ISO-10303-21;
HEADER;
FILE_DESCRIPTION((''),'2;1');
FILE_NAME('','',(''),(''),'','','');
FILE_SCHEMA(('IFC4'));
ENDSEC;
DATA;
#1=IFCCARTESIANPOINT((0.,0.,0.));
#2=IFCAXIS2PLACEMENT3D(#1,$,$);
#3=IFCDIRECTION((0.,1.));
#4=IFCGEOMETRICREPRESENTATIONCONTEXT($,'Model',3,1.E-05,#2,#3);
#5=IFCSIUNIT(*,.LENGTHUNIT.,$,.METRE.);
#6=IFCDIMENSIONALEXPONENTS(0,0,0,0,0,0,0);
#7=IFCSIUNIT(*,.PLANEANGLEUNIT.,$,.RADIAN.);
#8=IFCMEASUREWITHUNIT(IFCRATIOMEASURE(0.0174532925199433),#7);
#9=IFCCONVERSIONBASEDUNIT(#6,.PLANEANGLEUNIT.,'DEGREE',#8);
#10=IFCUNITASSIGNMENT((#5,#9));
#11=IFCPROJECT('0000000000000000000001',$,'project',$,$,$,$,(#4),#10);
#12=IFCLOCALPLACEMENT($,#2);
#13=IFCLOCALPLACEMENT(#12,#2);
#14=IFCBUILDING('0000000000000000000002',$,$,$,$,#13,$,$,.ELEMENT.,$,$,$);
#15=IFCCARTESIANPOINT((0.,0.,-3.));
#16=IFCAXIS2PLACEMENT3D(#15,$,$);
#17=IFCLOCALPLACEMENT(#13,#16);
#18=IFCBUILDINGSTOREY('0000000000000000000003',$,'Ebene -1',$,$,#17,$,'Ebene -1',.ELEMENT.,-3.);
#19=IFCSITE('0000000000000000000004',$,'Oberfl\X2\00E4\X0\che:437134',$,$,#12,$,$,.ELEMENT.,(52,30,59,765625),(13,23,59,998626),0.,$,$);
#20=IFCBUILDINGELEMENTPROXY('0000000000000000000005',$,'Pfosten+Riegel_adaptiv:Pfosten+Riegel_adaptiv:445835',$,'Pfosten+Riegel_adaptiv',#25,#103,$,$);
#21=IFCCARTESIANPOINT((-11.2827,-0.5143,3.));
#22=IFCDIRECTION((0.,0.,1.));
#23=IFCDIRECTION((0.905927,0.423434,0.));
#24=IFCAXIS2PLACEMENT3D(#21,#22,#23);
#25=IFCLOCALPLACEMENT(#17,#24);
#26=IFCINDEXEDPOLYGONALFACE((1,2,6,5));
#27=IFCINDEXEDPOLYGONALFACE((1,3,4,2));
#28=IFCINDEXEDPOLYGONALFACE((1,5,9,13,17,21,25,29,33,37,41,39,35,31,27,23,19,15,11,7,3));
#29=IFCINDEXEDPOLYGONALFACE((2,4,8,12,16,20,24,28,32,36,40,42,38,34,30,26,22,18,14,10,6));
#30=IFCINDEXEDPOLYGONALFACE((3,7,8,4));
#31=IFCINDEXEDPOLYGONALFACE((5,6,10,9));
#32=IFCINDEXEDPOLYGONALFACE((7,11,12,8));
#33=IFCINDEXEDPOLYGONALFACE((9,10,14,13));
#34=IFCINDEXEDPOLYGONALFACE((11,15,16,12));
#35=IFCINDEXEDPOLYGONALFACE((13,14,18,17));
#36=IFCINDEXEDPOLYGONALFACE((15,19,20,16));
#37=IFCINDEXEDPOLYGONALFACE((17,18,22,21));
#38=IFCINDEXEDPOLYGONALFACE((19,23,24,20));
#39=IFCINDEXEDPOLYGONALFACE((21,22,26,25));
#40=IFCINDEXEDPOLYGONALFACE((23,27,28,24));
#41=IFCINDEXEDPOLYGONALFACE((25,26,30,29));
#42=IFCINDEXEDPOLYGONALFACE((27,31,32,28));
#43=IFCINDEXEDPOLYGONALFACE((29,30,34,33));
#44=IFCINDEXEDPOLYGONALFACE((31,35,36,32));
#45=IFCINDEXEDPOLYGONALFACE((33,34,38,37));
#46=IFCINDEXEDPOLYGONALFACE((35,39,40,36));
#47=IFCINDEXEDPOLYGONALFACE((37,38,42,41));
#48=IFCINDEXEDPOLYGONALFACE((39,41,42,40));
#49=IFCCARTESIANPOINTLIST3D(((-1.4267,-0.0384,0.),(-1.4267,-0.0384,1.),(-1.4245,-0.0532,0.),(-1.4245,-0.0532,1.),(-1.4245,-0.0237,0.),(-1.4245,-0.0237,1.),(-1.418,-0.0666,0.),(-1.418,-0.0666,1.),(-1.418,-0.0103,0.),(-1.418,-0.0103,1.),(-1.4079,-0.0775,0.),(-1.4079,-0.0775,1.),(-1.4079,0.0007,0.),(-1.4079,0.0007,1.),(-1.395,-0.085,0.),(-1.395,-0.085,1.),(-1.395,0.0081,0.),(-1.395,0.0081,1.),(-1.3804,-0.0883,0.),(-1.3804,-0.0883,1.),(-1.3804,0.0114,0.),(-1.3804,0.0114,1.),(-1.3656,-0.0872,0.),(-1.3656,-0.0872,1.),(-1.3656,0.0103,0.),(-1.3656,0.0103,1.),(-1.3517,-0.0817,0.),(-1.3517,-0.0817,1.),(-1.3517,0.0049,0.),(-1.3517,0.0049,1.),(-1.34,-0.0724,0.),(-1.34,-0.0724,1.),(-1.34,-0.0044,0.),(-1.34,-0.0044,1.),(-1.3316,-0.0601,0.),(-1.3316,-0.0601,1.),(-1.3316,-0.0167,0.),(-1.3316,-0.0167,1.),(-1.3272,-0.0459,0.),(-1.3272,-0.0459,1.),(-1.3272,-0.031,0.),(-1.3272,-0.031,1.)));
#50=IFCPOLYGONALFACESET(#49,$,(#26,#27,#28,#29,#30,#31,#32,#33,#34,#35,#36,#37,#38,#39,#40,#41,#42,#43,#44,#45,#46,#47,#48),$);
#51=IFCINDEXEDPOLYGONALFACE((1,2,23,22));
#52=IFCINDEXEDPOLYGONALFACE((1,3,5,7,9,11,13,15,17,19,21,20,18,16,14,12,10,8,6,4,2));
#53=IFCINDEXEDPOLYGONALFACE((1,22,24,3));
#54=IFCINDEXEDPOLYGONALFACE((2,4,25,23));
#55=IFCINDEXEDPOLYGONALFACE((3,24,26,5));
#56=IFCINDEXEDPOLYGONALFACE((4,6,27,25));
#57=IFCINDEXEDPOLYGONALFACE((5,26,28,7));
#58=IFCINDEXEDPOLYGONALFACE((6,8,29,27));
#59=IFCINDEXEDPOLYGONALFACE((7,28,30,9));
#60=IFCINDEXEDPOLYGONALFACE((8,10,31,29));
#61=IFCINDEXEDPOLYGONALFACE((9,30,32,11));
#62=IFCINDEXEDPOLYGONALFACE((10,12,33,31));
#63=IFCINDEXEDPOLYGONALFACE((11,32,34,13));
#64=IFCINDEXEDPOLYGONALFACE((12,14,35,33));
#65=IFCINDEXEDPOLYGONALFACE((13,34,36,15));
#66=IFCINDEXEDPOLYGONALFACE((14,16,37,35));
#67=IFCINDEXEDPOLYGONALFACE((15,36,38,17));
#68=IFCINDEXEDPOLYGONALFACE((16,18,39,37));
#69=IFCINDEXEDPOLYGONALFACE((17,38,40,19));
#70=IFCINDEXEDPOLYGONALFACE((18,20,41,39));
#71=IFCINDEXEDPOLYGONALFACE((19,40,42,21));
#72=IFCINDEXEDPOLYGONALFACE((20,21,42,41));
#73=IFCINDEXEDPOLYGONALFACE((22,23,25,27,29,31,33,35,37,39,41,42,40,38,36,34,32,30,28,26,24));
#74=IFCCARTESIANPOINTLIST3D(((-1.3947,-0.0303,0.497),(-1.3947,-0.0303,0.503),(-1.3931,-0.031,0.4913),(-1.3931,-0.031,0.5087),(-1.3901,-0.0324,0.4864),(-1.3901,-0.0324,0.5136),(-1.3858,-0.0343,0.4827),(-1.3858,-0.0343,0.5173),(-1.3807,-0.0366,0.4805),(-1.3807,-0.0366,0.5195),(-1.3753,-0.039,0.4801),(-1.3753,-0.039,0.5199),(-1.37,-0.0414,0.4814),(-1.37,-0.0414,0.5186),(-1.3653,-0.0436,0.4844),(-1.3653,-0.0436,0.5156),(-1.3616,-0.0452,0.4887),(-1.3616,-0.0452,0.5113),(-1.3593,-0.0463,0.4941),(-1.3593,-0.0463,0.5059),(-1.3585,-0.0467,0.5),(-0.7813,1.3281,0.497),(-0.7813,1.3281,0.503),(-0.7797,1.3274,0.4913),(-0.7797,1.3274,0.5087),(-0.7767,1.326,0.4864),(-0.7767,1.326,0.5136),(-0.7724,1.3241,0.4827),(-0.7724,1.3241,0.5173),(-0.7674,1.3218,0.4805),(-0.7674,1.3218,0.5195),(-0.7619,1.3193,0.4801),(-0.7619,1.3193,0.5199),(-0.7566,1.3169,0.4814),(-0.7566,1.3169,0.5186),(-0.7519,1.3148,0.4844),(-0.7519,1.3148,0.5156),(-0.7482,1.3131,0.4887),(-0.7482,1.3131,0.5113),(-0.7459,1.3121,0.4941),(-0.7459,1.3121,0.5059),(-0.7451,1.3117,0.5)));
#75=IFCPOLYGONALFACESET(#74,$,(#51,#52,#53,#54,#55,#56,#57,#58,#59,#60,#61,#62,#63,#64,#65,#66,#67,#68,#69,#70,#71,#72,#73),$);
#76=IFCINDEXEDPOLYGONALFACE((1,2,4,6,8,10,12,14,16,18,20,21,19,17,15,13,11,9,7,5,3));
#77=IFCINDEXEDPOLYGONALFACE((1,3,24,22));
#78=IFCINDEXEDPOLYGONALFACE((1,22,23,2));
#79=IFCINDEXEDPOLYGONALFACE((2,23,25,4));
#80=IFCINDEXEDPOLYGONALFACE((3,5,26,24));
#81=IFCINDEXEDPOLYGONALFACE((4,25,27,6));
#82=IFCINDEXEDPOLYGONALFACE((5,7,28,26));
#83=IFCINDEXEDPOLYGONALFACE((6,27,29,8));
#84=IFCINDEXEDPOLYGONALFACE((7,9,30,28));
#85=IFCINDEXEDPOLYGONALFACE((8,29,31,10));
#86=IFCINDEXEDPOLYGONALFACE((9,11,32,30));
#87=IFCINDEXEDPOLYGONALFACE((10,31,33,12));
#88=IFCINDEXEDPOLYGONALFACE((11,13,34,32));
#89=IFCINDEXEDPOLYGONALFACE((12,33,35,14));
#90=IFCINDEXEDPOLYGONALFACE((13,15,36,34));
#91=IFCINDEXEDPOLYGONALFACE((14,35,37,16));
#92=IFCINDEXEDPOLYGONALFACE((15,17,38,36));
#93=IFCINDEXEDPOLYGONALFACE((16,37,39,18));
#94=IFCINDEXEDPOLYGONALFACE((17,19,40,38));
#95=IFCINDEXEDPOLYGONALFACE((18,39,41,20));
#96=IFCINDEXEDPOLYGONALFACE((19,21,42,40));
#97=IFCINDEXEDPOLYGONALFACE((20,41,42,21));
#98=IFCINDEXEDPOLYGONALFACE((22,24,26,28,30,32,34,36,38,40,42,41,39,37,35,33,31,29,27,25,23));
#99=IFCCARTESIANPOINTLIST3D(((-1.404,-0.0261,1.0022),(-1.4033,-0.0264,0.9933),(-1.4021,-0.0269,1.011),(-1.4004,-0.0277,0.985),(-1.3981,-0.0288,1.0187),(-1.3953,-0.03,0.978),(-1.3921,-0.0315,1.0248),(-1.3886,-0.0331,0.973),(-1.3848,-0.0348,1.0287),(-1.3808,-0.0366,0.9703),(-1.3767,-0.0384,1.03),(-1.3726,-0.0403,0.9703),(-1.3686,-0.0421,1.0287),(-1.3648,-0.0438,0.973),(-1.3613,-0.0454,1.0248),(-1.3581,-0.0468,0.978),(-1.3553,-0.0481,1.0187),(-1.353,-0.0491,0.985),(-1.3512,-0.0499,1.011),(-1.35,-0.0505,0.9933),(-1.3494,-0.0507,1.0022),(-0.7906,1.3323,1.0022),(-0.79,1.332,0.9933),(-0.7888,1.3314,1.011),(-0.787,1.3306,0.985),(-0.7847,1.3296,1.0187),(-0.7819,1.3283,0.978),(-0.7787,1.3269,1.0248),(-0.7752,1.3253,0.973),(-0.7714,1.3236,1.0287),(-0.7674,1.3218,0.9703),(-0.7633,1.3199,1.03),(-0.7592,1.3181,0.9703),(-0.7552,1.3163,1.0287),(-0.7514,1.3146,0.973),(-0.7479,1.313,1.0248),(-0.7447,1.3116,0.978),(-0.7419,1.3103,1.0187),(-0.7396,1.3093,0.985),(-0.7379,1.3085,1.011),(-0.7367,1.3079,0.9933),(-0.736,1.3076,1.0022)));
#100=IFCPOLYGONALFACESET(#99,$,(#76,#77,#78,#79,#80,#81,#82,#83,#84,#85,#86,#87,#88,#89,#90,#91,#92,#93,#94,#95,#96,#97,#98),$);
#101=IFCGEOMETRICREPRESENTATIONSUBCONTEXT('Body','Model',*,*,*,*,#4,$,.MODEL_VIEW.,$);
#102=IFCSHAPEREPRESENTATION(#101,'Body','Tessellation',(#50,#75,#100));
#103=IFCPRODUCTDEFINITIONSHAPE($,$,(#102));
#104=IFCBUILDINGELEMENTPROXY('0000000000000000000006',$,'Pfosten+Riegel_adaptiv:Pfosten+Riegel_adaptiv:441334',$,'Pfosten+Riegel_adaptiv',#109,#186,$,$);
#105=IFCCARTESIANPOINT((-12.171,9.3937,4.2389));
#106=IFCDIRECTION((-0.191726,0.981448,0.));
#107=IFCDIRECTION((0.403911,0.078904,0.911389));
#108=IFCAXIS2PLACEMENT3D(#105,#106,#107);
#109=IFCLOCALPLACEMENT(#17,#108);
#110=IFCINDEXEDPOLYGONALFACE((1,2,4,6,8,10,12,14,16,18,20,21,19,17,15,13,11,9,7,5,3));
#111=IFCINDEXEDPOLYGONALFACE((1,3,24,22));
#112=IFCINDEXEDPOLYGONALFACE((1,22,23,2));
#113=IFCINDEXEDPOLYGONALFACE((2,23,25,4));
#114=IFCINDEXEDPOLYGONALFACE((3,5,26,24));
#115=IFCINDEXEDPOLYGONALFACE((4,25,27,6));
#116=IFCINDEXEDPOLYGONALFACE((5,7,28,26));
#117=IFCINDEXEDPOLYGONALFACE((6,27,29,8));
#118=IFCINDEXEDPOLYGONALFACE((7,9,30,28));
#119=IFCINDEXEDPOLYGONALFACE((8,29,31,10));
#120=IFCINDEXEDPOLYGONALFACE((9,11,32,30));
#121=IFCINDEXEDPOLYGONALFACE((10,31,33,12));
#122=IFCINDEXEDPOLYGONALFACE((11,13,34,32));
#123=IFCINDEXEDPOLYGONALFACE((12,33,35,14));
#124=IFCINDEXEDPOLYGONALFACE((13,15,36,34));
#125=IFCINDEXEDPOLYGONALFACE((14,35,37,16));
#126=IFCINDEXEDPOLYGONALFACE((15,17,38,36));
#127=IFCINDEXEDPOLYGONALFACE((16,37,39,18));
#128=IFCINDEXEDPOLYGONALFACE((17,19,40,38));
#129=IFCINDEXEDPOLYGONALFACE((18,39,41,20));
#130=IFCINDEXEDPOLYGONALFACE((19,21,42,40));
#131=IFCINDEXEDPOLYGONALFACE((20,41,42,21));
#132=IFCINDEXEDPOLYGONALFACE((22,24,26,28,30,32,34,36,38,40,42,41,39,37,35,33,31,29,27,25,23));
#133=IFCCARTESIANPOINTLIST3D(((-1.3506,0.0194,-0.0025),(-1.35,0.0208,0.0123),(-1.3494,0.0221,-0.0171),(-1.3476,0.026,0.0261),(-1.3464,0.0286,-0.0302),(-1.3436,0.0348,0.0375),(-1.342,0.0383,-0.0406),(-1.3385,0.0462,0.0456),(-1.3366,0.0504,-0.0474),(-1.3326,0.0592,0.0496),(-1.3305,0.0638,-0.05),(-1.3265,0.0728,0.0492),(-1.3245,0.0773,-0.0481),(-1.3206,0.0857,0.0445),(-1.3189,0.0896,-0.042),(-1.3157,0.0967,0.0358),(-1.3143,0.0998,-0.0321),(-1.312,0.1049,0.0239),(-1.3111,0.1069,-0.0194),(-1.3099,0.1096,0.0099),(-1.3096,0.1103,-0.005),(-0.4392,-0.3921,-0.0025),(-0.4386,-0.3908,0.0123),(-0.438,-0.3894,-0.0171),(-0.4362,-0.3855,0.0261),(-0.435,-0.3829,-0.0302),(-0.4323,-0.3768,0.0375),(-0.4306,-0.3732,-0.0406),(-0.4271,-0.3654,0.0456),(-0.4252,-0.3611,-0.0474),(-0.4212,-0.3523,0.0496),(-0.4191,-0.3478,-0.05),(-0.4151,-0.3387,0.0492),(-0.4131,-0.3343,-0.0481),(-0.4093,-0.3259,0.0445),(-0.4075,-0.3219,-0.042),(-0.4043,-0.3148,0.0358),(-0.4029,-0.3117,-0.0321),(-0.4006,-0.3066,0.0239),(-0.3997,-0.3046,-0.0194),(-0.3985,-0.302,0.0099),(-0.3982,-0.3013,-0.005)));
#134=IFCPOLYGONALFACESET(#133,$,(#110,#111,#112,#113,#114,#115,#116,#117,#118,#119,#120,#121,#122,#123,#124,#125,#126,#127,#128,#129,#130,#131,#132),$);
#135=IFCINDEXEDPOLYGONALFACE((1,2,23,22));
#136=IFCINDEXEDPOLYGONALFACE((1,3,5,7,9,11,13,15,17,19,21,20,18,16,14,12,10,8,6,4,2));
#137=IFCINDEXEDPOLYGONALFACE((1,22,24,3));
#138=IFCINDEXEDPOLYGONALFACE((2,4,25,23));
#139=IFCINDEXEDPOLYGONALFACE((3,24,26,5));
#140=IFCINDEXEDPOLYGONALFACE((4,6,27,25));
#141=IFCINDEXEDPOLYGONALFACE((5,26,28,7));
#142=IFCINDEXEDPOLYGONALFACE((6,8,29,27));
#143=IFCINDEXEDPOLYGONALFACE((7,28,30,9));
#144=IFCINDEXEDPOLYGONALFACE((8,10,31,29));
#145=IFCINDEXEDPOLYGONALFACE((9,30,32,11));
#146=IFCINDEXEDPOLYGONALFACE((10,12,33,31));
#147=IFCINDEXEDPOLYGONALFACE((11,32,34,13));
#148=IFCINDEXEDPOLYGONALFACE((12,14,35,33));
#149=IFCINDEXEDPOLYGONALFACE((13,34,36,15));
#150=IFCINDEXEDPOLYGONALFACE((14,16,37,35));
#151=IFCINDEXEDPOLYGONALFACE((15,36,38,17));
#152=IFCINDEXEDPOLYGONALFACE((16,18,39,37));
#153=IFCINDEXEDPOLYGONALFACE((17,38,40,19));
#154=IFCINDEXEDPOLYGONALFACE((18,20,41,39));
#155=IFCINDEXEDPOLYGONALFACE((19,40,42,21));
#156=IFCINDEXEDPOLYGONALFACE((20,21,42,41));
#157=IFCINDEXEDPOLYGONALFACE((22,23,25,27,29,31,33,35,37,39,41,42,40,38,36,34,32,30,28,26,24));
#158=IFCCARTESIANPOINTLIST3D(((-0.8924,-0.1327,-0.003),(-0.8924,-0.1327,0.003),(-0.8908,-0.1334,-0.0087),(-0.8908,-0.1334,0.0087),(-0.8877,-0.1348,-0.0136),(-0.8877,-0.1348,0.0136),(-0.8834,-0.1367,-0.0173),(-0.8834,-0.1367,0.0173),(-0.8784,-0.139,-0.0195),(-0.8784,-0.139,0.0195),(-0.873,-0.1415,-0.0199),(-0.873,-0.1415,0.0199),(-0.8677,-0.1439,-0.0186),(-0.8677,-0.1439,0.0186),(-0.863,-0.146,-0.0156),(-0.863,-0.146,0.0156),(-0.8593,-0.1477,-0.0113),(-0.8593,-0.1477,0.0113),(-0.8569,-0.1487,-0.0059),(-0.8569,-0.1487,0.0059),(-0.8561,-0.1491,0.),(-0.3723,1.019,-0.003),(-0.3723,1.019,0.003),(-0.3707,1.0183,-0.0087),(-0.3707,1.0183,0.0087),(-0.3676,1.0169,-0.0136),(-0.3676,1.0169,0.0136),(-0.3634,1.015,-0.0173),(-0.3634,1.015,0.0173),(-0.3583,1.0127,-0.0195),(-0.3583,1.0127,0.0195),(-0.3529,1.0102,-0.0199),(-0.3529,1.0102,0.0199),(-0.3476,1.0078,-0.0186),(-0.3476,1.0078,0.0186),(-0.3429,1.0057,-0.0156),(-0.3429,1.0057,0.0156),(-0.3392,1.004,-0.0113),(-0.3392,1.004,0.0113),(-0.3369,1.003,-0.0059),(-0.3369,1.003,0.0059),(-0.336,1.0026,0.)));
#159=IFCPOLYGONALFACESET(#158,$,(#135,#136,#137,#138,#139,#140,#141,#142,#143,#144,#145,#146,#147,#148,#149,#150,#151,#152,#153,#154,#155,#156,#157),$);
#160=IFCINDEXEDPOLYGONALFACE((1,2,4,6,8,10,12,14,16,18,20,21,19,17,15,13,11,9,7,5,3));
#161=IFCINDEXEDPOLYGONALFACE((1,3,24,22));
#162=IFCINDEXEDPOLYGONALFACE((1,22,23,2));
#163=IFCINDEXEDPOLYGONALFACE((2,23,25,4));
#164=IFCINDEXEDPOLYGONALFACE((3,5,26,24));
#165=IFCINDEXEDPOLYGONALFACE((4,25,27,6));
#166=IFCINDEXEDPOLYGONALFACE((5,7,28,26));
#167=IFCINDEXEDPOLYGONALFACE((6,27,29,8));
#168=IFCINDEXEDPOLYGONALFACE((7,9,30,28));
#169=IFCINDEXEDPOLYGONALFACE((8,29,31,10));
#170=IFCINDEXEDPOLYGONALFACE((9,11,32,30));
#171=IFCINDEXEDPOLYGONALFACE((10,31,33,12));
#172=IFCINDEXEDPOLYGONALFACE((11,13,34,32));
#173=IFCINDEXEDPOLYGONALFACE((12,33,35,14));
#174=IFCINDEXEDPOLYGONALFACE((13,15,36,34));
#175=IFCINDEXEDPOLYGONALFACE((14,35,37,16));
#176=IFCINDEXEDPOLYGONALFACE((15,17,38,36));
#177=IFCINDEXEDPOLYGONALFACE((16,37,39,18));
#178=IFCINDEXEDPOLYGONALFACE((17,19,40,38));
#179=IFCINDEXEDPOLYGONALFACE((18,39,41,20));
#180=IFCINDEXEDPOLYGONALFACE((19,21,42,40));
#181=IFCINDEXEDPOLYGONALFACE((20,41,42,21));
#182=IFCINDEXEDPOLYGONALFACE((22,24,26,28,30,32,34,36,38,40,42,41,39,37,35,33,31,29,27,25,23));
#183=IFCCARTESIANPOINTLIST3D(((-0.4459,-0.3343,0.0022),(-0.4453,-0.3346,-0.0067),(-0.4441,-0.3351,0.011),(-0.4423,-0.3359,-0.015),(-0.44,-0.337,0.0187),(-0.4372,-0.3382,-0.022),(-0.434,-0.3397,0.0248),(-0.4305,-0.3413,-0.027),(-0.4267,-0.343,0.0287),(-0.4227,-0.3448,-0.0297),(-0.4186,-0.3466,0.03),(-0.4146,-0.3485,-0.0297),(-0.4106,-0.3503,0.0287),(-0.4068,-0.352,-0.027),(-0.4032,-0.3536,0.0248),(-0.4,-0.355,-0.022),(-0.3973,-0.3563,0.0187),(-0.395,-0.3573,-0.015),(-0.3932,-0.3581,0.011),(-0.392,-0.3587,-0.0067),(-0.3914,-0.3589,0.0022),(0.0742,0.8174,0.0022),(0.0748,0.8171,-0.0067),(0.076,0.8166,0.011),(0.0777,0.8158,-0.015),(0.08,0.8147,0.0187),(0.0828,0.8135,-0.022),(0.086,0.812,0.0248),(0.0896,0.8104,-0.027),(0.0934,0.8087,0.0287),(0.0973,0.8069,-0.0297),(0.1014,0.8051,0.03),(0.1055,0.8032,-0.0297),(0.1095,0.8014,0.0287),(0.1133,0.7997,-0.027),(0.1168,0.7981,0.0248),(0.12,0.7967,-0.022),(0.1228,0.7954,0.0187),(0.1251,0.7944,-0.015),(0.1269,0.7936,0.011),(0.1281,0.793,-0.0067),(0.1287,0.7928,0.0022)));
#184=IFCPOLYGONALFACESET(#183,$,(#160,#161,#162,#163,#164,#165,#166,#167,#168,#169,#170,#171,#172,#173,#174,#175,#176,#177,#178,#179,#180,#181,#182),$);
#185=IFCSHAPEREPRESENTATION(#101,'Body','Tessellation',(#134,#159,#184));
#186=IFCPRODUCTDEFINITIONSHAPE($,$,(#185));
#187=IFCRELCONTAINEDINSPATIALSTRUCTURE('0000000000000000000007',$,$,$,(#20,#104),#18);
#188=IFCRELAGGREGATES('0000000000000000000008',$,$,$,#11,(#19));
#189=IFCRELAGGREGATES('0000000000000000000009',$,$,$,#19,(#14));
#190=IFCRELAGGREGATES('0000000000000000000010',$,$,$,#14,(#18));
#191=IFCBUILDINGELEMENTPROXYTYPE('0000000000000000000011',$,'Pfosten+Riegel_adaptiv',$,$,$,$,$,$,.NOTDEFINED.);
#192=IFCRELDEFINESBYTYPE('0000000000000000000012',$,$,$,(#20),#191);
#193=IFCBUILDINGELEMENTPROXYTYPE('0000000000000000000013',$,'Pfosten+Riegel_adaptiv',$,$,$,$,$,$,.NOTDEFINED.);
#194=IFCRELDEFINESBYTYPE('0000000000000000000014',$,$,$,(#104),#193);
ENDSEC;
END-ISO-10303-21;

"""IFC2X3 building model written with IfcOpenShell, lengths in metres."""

from ifc_helpers import new_model, entity, si_unit, converted_unit, direction, frame, frame_2d, origin, place, context, subcontext, project, spatial, circle, extrude, source, transform, mapped, type_object, type_shapes, element, save


model = new_model("IFC2X3")

# Units and contexts
model_context = context("Model", 3, precision=1e-05, world=origin(), true_north=direction((0.0, 1.0)))
body_context = subcontext(model_context, "Body", "Model", "MODEL_VIEW")
ifc_project = project(units=[si_unit("LENGTHUNIT", "METRE"), converted_unit("PLANEANGLEUNIT", "DEGREE", entity("IfcRatioMeasure", 0.0174532925199433), si_unit("PLANEANGLEUNIT", "RADIAN"), dimensions=[0, 0, 0, 0, 0, 0, 0])], contexts=[model_context])

# Site, building, storey
site_placement = place(None, origin())
site = spatial("IfcSite", under=ifc_project, at=site_placement, Name="Oberfläche:437134", CompositionType="ELEMENT", RefLatitude=(52, 30, 59, 765625), RefLongitude=(13, 23, 59, 998626), RefElevation=0.0)
building_placement = place(site_placement, origin())
building = spatial("IfcBuilding", under=site, at=building_placement, CompositionType="ELEMENT")
storey_placement = place(building_placement, frame((0.0, 0.0, -3.0)))
storey = spatial("IfcBuildingStorey", under=building, at=storey_placement, Name="Ebene -1", LongName="Ebene -1", CompositionType="ELEMENT", Elevation=-3.0)

# Building element proxies
building_element_proxy_type_1 = type_object("IfcBuildingElementProxyType", Name="Pfosten+Riegel_adaptiv", PredefinedType="NOTDEFINED")
shared_shape_1 = source(origin(), body_context, "Body", "SweptSolid", [
    extrude(circle(Radius=0.05, at=frame_2d((0.0, 0.0), x_axis=(1.0, 0.0))), frame((-1.3767, -0.0384, 0.0), z_axis=(0.0, 0.0, 1.0), x_axis=(-1.0, 0.0, 0.0)), (0.0, 0.0, 1.0), 1.0),
    extrude(circle(Radius=0.02, at=frame_2d((0.0, 0.0), x_axis=(1.0, 0.0))), frame((-1.3767, -0.0384, 0.5), z_axis=(0.411546, 0.911389, 0.0), x_axis=(0.911389, -0.411546, 0.0)), (0.0, 0.0, 1.0), 1.4904),
    extrude(circle(Radius=0.03, at=frame_2d((0.0, 0.0), x_axis=(1.0, 0.0))), frame((-1.3767, -0.0384, 1.0), z_axis=(0.411546, 0.911389, 0.0), x_axis=(0.0, 0.0, 1.0)), (0.0, 0.0, 1.0), 1.4904),
])
type_shapes(building_element_proxy_type_1, [shared_shape_1])
for number, where, z_axis, x_axis, name in (
    (1, (-11.2827, -0.5143, 3.0), (0.0, 0.0, 1.0), (0.905927, 0.423434, 0.0), "Pfosten+Riegel_adaptiv:Pfosten+Riegel_adaptiv:445835"),
):
    element("IfcBuildingElementProxy", number, at=place(storey_placement, frame(where, z_axis=z_axis, x_axis=x_axis)), inside=storey, type_object=building_element_proxy_type_1, Name=name, ObjectType="Pfosten+Riegel_adaptiv", context=body_context, shape_type="MappedRepresentation", body=[
        mapped(shared_shape_1, transform((0.0, 0.0, 0.0), scale=1.0)),
    ])
building_element_proxy_type_2 = type_object("IfcBuildingElementProxyType", Name="Pfosten+Riegel_adaptiv", PredefinedType="NOTDEFINED")
shared_shape_2 = source(origin(), body_context, "Body", "SweptSolid", [
    extrude(circle(Radius=0.05, at=frame_2d((0.0, 0.0), x_axis=(1.0, 0.0))), frame((-1.33, 0.0649, 0.0), z_axis=(0.911389, -0.411546, 0.0), x_axis=(-0.16937, -0.375078, 0.911389)), (0.0, 0.0, 1.0), 1.0),
    extrude(circle(Radius=0.02, at=frame_2d((0.0, 0.0), x_axis=(1.0, 0.0))), frame((-0.8743, -0.1409, 0.0), z_axis=(0.411546, 0.911389, 0.0), x_axis=(0.911389, -0.411546, 0.0)), (0.0, 0.0, 1.0), 1.2637),
    extrude(circle(Radius=0.03, at=frame_2d((0.0, 0.0), x_axis=(1.0, 0.0))), frame((-0.4186, -0.3466, 0.0), z_axis=(0.411546, 0.911389, 0.0), x_axis=(0.0, 0.0, 1.0)), (0.0, 0.0, 1.0), 1.2637),
])
type_shapes(building_element_proxy_type_2, [shared_shape_2])
proxy_1_placement = place(storey_placement, frame((-12.171, 9.3937, 4.2389), z_axis=(-0.191726, 0.981448, 0.0), x_axis=(0.403911, 0.078904, 0.911389)))
element("IfcBuildingElementProxy", 2, at=proxy_1_placement, inside=storey, type_object=building_element_proxy_type_2, Name="Pfosten+Riegel_adaptiv:Pfosten+Riegel_adaptiv:441334", ObjectType="Pfosten+Riegel_adaptiv", context=body_context, shape_type="MappedRepresentation", body=[
    mapped(shared_shape_2, transform((0.0, 0.0, 0.0), scale=1.0)),
])

save(model, "model.ifc")
